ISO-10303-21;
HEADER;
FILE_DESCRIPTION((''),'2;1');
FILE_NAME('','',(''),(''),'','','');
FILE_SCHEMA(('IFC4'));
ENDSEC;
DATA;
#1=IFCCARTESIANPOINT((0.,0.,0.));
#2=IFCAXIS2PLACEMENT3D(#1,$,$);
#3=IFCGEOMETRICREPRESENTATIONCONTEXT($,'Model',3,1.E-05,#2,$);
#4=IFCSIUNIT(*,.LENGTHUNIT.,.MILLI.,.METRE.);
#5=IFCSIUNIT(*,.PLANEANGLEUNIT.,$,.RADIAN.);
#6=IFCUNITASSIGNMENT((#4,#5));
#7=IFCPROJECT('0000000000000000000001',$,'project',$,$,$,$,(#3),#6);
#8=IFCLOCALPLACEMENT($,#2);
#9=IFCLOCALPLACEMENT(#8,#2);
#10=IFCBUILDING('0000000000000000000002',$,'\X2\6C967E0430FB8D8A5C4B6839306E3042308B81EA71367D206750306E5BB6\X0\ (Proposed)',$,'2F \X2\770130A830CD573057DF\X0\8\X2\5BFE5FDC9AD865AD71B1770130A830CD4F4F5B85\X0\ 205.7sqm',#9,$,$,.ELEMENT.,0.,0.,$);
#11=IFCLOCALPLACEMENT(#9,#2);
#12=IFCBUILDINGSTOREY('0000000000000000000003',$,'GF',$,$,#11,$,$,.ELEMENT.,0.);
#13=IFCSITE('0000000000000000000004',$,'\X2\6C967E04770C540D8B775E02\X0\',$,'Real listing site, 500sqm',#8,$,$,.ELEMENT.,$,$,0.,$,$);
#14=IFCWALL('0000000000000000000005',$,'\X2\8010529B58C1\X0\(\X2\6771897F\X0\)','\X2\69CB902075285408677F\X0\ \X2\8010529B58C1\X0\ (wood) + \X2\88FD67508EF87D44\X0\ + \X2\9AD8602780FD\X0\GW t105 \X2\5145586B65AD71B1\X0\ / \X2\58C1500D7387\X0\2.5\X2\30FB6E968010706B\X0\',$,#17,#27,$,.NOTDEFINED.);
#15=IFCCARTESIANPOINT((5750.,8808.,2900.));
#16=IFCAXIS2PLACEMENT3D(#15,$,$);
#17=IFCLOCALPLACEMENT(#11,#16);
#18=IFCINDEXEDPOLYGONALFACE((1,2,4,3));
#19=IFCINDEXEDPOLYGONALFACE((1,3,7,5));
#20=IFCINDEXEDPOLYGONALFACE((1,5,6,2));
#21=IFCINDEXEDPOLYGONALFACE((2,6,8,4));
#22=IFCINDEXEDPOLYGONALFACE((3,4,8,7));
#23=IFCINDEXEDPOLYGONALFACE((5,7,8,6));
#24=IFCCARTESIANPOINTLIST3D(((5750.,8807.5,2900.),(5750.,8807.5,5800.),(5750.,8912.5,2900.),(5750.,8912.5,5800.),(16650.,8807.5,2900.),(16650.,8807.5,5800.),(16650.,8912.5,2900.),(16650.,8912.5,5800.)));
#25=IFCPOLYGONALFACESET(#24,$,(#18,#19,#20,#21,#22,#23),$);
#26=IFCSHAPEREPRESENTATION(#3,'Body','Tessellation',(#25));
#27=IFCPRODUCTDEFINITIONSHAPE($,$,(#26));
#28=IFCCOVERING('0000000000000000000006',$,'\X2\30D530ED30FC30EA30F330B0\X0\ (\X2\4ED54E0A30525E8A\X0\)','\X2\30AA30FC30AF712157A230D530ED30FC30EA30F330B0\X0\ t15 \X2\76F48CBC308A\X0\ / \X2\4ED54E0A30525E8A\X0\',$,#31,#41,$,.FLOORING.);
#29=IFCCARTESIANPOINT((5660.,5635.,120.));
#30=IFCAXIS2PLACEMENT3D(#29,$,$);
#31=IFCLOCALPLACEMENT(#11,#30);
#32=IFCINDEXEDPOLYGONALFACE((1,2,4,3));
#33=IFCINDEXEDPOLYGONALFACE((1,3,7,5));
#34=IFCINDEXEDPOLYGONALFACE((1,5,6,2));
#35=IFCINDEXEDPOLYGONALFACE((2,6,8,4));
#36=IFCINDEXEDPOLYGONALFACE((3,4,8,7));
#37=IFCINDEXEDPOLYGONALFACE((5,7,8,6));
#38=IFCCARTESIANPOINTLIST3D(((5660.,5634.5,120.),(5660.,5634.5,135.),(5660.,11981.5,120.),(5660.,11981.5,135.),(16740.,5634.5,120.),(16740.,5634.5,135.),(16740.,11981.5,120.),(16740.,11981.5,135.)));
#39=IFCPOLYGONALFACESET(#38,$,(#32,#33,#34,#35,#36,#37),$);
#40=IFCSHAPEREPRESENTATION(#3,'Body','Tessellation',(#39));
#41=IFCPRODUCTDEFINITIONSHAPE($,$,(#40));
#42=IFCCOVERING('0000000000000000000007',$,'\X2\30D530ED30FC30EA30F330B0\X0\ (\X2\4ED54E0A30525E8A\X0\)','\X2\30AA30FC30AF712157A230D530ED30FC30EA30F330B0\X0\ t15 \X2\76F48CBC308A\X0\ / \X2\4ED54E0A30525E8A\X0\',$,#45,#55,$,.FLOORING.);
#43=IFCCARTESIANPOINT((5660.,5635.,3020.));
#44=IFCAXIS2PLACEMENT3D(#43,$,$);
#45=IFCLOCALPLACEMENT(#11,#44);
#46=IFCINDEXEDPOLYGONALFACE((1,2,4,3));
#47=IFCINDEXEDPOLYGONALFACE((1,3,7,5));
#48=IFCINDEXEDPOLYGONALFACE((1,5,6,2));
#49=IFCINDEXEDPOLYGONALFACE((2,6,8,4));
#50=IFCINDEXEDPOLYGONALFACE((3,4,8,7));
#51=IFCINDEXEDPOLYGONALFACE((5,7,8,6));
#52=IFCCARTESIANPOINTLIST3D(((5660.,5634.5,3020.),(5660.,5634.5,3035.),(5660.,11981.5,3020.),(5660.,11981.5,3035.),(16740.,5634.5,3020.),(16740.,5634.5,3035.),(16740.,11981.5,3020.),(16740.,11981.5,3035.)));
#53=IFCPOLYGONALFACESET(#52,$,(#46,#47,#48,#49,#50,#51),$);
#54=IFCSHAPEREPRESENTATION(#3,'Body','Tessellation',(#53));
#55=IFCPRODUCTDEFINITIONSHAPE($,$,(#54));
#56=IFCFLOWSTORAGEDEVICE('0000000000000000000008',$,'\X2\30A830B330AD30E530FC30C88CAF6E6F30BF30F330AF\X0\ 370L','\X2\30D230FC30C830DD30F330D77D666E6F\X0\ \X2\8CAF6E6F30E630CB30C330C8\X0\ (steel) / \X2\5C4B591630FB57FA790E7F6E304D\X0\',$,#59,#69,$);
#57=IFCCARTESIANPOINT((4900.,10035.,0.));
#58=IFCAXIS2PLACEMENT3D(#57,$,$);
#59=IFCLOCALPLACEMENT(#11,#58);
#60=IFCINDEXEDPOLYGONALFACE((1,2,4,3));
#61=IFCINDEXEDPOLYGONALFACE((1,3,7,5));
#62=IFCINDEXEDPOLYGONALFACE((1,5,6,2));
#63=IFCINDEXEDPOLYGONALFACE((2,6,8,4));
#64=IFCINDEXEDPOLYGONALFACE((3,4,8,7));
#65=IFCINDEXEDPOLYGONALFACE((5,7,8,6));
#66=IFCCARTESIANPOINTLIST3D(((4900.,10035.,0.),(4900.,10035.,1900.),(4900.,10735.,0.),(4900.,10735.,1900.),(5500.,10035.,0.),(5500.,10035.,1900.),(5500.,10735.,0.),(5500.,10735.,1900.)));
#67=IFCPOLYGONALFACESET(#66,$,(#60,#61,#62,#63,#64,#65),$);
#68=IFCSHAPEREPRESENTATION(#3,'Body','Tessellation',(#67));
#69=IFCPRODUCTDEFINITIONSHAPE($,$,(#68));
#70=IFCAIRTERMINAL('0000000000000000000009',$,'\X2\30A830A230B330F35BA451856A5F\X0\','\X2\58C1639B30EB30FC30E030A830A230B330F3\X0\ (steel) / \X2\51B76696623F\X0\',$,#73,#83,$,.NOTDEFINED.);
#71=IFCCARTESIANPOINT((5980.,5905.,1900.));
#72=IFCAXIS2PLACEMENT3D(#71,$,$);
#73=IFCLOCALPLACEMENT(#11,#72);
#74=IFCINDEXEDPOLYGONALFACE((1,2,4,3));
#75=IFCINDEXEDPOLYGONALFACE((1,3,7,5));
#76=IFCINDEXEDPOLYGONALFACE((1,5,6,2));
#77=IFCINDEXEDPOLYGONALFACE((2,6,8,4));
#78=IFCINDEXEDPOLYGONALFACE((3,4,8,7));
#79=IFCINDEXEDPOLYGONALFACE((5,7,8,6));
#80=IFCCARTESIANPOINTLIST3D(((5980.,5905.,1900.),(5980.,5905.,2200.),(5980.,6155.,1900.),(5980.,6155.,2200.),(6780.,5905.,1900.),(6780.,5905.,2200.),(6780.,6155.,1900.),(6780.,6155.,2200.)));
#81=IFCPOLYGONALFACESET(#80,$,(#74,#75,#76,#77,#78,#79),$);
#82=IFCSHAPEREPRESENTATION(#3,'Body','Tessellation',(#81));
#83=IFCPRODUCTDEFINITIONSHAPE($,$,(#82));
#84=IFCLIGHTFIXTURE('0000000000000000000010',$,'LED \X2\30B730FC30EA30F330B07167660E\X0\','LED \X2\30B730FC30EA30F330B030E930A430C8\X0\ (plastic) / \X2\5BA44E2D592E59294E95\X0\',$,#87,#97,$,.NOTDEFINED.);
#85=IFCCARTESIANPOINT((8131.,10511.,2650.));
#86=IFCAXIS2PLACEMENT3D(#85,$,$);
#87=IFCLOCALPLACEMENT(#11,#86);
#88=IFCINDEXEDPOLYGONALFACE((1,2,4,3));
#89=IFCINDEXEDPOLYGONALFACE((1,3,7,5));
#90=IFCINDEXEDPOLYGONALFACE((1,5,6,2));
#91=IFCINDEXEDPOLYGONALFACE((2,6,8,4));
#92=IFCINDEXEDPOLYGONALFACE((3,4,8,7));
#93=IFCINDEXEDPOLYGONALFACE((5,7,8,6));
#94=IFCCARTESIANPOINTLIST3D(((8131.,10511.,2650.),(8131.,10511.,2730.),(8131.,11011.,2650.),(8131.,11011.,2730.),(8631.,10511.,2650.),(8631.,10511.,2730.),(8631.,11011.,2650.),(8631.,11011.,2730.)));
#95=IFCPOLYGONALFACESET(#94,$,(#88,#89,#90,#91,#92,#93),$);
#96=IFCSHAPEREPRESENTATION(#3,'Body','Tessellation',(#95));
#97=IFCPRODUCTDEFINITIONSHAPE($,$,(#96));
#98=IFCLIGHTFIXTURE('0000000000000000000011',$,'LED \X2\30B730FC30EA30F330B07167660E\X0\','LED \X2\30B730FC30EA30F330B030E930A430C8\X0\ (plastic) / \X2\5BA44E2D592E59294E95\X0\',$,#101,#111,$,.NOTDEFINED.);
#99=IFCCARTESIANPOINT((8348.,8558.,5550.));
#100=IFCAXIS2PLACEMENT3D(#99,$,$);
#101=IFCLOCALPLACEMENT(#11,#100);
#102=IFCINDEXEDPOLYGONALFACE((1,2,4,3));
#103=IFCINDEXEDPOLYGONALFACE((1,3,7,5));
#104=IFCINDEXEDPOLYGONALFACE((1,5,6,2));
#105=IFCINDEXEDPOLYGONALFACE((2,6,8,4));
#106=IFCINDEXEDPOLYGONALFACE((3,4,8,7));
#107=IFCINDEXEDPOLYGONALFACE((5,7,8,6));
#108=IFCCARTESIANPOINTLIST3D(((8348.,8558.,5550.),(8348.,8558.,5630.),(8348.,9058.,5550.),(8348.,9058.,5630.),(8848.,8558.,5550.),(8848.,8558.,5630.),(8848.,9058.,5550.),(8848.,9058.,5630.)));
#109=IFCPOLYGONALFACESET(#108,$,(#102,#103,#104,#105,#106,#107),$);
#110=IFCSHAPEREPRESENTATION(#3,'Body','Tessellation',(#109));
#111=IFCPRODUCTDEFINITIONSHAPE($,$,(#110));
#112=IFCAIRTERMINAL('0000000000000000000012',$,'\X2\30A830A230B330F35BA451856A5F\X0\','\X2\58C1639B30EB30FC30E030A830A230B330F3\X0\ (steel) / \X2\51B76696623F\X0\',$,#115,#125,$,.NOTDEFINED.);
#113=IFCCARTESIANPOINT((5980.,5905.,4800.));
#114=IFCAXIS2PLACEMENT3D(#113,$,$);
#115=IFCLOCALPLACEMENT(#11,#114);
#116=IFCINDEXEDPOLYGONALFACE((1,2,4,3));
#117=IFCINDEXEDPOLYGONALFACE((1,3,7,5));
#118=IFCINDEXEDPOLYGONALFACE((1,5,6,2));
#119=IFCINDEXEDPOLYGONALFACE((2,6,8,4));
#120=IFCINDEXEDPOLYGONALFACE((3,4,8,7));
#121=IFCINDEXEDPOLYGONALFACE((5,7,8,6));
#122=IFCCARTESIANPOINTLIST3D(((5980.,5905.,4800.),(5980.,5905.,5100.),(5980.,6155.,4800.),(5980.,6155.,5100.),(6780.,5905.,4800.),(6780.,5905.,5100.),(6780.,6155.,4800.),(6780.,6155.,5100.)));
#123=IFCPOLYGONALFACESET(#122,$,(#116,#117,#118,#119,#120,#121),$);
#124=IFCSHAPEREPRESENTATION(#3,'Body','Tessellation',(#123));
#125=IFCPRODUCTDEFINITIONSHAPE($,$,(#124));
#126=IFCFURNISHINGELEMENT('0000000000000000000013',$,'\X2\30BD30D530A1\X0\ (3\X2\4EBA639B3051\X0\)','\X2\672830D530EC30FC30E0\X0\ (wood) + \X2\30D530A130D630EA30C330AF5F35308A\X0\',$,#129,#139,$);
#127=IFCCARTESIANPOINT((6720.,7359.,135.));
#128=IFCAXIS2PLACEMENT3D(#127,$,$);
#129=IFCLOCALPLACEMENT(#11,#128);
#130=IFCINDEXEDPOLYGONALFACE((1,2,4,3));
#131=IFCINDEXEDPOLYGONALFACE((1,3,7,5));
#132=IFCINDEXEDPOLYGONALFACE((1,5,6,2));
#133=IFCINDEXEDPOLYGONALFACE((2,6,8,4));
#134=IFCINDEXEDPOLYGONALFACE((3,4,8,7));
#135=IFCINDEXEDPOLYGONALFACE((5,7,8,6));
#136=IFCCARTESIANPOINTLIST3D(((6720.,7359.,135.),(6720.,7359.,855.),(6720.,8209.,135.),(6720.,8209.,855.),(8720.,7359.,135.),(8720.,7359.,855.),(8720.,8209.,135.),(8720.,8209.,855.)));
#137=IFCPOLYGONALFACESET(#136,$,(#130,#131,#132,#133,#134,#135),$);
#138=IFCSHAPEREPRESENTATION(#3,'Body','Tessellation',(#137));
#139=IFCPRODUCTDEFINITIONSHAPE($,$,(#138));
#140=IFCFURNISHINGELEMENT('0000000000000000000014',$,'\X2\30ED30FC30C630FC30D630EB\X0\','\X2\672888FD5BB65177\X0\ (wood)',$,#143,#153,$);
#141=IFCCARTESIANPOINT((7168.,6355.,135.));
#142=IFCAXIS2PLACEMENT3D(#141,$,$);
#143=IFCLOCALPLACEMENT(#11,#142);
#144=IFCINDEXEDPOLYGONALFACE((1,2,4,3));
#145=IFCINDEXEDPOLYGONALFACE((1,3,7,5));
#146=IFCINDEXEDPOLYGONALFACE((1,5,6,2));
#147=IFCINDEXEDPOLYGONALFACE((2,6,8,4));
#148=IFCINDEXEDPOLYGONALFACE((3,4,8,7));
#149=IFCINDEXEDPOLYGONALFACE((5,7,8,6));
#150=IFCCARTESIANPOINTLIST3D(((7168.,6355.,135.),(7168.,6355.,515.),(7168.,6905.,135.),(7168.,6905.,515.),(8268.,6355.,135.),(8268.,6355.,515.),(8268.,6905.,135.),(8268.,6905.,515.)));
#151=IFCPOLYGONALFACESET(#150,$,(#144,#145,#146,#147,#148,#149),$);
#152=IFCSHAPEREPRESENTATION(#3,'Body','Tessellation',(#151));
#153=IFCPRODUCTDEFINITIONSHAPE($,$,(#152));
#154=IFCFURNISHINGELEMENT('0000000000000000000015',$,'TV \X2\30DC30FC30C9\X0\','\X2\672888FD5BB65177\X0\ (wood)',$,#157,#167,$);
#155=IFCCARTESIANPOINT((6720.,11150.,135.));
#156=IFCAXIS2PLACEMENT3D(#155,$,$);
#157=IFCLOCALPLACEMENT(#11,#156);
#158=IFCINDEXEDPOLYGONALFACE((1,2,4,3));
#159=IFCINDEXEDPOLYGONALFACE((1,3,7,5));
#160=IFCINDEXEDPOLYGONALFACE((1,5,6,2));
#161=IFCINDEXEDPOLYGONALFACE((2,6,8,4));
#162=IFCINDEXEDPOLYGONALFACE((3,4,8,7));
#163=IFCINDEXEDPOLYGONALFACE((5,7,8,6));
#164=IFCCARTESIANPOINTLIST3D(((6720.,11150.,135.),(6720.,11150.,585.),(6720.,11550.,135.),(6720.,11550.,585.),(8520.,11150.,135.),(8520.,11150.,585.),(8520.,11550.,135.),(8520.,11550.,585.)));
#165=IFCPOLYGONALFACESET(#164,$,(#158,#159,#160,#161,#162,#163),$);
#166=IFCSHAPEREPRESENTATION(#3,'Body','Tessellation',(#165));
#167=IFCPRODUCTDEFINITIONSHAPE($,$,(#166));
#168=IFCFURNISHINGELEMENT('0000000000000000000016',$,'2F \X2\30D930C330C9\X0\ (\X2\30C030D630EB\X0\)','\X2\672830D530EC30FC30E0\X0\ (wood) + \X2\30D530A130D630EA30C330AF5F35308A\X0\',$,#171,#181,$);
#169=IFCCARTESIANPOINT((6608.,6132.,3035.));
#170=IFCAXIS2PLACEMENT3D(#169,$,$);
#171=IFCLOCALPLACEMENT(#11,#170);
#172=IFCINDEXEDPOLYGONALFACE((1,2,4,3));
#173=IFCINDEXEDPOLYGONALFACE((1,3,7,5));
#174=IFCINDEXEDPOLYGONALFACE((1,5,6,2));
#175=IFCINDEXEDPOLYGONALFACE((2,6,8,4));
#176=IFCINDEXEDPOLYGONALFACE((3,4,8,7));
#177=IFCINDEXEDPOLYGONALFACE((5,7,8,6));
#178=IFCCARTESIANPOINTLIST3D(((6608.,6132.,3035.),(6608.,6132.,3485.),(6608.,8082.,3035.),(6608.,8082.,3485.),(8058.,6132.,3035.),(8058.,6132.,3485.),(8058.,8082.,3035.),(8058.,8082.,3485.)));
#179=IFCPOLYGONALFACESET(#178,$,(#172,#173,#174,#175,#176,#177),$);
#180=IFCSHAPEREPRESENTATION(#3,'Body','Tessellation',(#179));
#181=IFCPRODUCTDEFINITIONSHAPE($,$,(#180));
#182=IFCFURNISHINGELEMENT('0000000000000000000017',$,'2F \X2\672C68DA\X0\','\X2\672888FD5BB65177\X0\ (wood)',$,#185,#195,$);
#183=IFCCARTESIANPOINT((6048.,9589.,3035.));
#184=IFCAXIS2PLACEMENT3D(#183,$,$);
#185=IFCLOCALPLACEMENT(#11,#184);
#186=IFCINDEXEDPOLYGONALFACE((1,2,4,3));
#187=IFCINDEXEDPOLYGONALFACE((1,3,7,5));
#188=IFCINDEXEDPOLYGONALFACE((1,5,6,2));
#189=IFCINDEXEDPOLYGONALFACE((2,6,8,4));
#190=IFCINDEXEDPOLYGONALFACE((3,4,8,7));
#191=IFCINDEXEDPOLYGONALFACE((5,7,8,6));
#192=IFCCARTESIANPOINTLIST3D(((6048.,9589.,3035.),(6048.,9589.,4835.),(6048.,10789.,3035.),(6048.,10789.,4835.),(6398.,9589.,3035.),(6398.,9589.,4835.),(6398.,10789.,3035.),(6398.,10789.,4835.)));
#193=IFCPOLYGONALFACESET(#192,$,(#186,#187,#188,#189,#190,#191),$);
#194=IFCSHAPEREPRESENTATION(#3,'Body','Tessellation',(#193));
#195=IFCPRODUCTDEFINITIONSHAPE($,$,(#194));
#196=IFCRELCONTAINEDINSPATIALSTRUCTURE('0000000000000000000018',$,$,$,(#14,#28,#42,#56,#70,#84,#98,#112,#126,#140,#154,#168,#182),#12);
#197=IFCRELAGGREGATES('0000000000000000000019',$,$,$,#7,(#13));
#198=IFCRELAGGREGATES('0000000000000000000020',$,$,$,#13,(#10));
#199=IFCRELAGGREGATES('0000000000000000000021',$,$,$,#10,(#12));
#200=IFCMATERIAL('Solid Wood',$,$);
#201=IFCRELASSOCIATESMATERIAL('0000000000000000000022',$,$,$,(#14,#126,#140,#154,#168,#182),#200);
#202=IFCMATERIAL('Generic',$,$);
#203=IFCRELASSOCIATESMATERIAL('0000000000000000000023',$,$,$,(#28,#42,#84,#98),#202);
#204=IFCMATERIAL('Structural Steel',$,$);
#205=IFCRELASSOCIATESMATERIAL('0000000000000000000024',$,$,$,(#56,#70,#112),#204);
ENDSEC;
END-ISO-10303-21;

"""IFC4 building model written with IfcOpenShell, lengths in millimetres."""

from ifc_helpers import new_model, si_unit, frame, frame_2d, origin, place, context, project, spatial, rectangle, extrude, material, element, save


model = new_model("IFC4")

# Units and contexts
model_context = context("Model", 3, precision=1e-05, world=origin())
ifc_project = project(units=[si_unit("LENGTHUNIT", "METRE", prefix="MILLI"), si_unit("PLANEANGLEUNIT", "RADIAN")], contexts=[model_context])

# Site, building, storey
site_placement = place(None, origin())
site = spatial("IfcSite", under=ifc_project, at=site_placement, Name="沖縄県名護市", ObjectType="Real listing site, 500sqm", CompositionType="ELEMENT", RefElevation=0.0)
building_placement = place(site_placement, origin())
building = spatial("IfcBuilding", under=site, at=building_placement, Name="沖縄・越屋根のある自然素材の家 (Proposed)", ObjectType="2F 省エネ地域8対応高断熱省エネ住宅 205.7sqm", CompositionType="ELEMENT", ElevationOfRefHeight=0.0, ElevationOfTerrain=0.0)
storey_placement = place(building_placement, origin())
storey = spatial("IfcBuildingStorey", under=building, at=storey_placement, Name="GF", CompositionType="ELEMENT", Elevation=0.0)

# Shared definitions
ifc_material_1 = material(Name="Solid Wood")

# Wall
wall_1_placement = place(storey_placement, frame((5750.0, 8808.0, 2900.0)))
element("IfcWall", 1, at=wall_1_placement, inside=storey, material=ifc_material_1, Name="耐力壁(東西)", Description="構造用合板 耐力壁 (wood) + 製材軸組 + 高性能GW t105 充填断熱 / 壁倍率2.5・準耐火", PredefinedType="NOTDEFINED", context=model_context, shape_type="SweptSolid", body=[
    extrude(rectangle(XDim=10900.0, YDim=105.0, at=frame_2d((5450.0, 52.0))), frame((5750.0, 8808.0, 2900.0)), (0.0, 0.0, 1.0), 2900.0),
])

# Coverings
ifc_material_2 = material(Name="Generic")
covering_1_placement = place(storey_placement, frame((5660.0, 5635.0, 120.0)))
element("IfcCovering", 2, at=covering_1_placement, inside=storey, material=ifc_material_2, Name="フローリング (仕上げ床)", Description="オーク無垢フローリング t15 直貼り / 仕上げ床", PredefinedType="FLOORING", context=model_context, shape_type="SweptSolid", body=[
    extrude(rectangle(XDim=11080.0, YDim=6347.0, at=frame_2d((5540.0, 3173.0))), frame((5660.0, 5635.0, 120.0)), (0.0, 0.0, 1.0), 15.0),
])
covering_2_placement = place(storey_placement, frame((5660.0, 5635.0, 3020.0)))
element("IfcCovering", 3, at=covering_2_placement, inside=storey, material=ifc_material_2, Name="フローリング (仕上げ床)", Description="オーク無垢フローリング t15 直貼り / 仕上げ床", PredefinedType="FLOORING", context=model_context, shape_type="SweptSolid", body=[
    extrude(rectangle(XDim=11080.0, YDim=6347.0, at=frame_2d((5540.0, 3173.0))), frame((5660.0, 5635.0, 3020.0)), (0.0, 0.0, 1.0), 15.0),
])

# Flow storage device
ifc_material_3 = material(Name="Structural Steel")
flow_storage_device_placement = place(storey_placement, frame((4900.0, 10035.0, 0.0)))
element("IfcFlowStorageDevice", 4, at=flow_storage_device_placement, inside=storey, material=ifc_material_3, Name="エコキュート貯湯タンク 370L", Description="ヒートポンプ給湯 貯湯ユニット (steel) / 屋外・基礎置き", context=model_context, shape_type="SweptSolid", body=[
    extrude(rectangle(XDim=600.0, YDim=700.0, at=frame_2d((300.0, 350.0))), frame((4900.0, 10035.0, 0.0)), (0.0, 0.0, 1.0), 1900.0),
])

# Air terminal
air_terminal_1_placement = place(storey_placement, frame((5980.0, 5905.0, 1900.0)))
element("IfcAirTerminal", 5, at=air_terminal_1_placement, inside=storey, material=ifc_material_3, Name="エアコン室内機", Description="壁掛ルームエアコン (steel) / 冷暖房", PredefinedType="NOTDEFINED", context=model_context, shape_type="SweptSolid", body=[
    extrude(rectangle(XDim=800.0, YDim=250.0, at=frame_2d((400.0, 125.0))), frame((5980.0, 5905.0, 1900.0)), (0.0, 0.0, 1.0), 300.0),
])

# Light fixtures
light_fixture_1_placement = place(storey_placement, frame((8131.0, 10511.0, 2650.0)))
element("IfcLightFixture", 6, at=light_fixture_1_placement, inside=storey, material=ifc_material_2, Name="LED シーリング照明", Description="LED シーリングライト (plastic) / 室中央天井", PredefinedType="NOTDEFINED", context=model_context, shape_type="SweptSolid", body=[
    extrude(rectangle(XDim=500.0, YDim=500.0, at=frame_2d((250.0, 250.0))), frame((8131.0, 10511.0, 2650.0)), (0.0, 0.0, 1.0), 80.0),
])
light_fixture_2_placement = place(storey_placement, frame((8348.0, 8558.0, 5550.0)))
element("IfcLightFixture", 7, at=light_fixture_2_placement, inside=storey, material=ifc_material_2, Name="LED シーリング照明", Description="LED シーリングライト (plastic) / 室中央天井", PredefinedType="NOTDEFINED", context=model_context, shape_type="SweptSolid", body=[
    extrude(rectangle(XDim=500.0, YDim=500.0, at=frame_2d((250.0, 250.0))), frame((8348.0, 8558.0, 5550.0)), (0.0, 0.0, 1.0), 80.0),
])

# Air terminal
air_terminal_2_placement = place(storey_placement, frame((5980.0, 5905.0, 4800.0)))
element("IfcAirTerminal", 8, at=air_terminal_2_placement, inside=storey, material=ifc_material_3, Name="エアコン室内機", Description="壁掛ルームエアコン (steel) / 冷暖房", PredefinedType="NOTDEFINED", context=model_context, shape_type="SweptSolid", body=[
    extrude(rectangle(XDim=800.0, YDim=250.0, at=frame_2d((400.0, 125.0))), frame((5980.0, 5905.0, 4800.0)), (0.0, 0.0, 1.0), 300.0),
])

# Furnishing elements
furnishing_1_placement = place(storey_placement, frame((6720.0, 7359.0, 135.0)))
element("IfcFurnishingElement", 9, at=furnishing_1_placement, inside=storey, material=ifc_material_1, Name="ソファ (3人掛け)", Description="木フレーム (wood) + ファブリック張り", context=model_context, shape_type="SweptSolid", body=[
    extrude(rectangle(XDim=2000.0, YDim=850.0, at=frame_2d((1000.0, 425.0))), frame((6720.0, 7359.0, 135.0)), (0.0, 0.0, 1.0), 720.0),
])
furnishing_2_placement = place(storey_placement, frame((7168.0, 6355.0, 135.0)))
element("IfcFurnishingElement", 10, at=furnishing_2_placement, inside=storey, material=ifc_material_1, Name="ローテーブル", Description="木製家具 (wood)", context=model_context, shape_type="SweptSolid", body=[
    extrude(rectangle(XDim=1100.0, YDim=550.0, at=frame_2d((550.0, 275.0))), frame((7168.0, 6355.0, 135.0)), (0.0, 0.0, 1.0), 380.0),
])
furnishing_3_placement = place(storey_placement, frame((6720.0, 11150.0, 135.0)))
element("IfcFurnishingElement", 11, at=furnishing_3_placement, inside=storey, material=ifc_material_1, Name="TV ボード", Description="木製家具 (wood)", context=model_context, shape_type="SweptSolid", body=[
    extrude(rectangle(XDim=1800.0, YDim=400.0, at=frame_2d((900.0, 200.0))), frame((6720.0, 11150.0, 135.0)), (0.0, 0.0, 1.0), 450.0),
])
furnishing_4_placement = place(storey_placement, frame((6608.0, 6132.0, 3035.0)))
element("IfcFurnishingElement", 12, at=furnishing_4_placement, inside=storey, material=ifc_material_1, Name="2F ベッド (ダブル)", Description="木フレーム (wood) + ファブリック張り", context=model_context, shape_type="SweptSolid", body=[
    extrude(rectangle(XDim=1450.0, YDim=1950.0, at=frame_2d((725.0, 975.0))), frame((6608.0, 6132.0, 3035.0)), (0.0, 0.0, 1.0), 450.0),
])
furnishing_5_placement = place(storey_placement, frame((6048.0, 9589.0, 3035.0)))
element("IfcFurnishingElement", 13, at=furnishing_5_placement, inside=storey, material=ifc_material_1, Name="2F 本棚", Description="木製家具 (wood)", context=model_context, shape_type="SweptSolid", body=[
    extrude(rectangle(XDim=350.0, YDim=1200.0, at=frame_2d((175.0, 600.0))), frame((6048.0, 9589.0, 3035.0)), (0.0, 0.0, 1.0), 1800.0),
])

save(model, "model.ifc")
